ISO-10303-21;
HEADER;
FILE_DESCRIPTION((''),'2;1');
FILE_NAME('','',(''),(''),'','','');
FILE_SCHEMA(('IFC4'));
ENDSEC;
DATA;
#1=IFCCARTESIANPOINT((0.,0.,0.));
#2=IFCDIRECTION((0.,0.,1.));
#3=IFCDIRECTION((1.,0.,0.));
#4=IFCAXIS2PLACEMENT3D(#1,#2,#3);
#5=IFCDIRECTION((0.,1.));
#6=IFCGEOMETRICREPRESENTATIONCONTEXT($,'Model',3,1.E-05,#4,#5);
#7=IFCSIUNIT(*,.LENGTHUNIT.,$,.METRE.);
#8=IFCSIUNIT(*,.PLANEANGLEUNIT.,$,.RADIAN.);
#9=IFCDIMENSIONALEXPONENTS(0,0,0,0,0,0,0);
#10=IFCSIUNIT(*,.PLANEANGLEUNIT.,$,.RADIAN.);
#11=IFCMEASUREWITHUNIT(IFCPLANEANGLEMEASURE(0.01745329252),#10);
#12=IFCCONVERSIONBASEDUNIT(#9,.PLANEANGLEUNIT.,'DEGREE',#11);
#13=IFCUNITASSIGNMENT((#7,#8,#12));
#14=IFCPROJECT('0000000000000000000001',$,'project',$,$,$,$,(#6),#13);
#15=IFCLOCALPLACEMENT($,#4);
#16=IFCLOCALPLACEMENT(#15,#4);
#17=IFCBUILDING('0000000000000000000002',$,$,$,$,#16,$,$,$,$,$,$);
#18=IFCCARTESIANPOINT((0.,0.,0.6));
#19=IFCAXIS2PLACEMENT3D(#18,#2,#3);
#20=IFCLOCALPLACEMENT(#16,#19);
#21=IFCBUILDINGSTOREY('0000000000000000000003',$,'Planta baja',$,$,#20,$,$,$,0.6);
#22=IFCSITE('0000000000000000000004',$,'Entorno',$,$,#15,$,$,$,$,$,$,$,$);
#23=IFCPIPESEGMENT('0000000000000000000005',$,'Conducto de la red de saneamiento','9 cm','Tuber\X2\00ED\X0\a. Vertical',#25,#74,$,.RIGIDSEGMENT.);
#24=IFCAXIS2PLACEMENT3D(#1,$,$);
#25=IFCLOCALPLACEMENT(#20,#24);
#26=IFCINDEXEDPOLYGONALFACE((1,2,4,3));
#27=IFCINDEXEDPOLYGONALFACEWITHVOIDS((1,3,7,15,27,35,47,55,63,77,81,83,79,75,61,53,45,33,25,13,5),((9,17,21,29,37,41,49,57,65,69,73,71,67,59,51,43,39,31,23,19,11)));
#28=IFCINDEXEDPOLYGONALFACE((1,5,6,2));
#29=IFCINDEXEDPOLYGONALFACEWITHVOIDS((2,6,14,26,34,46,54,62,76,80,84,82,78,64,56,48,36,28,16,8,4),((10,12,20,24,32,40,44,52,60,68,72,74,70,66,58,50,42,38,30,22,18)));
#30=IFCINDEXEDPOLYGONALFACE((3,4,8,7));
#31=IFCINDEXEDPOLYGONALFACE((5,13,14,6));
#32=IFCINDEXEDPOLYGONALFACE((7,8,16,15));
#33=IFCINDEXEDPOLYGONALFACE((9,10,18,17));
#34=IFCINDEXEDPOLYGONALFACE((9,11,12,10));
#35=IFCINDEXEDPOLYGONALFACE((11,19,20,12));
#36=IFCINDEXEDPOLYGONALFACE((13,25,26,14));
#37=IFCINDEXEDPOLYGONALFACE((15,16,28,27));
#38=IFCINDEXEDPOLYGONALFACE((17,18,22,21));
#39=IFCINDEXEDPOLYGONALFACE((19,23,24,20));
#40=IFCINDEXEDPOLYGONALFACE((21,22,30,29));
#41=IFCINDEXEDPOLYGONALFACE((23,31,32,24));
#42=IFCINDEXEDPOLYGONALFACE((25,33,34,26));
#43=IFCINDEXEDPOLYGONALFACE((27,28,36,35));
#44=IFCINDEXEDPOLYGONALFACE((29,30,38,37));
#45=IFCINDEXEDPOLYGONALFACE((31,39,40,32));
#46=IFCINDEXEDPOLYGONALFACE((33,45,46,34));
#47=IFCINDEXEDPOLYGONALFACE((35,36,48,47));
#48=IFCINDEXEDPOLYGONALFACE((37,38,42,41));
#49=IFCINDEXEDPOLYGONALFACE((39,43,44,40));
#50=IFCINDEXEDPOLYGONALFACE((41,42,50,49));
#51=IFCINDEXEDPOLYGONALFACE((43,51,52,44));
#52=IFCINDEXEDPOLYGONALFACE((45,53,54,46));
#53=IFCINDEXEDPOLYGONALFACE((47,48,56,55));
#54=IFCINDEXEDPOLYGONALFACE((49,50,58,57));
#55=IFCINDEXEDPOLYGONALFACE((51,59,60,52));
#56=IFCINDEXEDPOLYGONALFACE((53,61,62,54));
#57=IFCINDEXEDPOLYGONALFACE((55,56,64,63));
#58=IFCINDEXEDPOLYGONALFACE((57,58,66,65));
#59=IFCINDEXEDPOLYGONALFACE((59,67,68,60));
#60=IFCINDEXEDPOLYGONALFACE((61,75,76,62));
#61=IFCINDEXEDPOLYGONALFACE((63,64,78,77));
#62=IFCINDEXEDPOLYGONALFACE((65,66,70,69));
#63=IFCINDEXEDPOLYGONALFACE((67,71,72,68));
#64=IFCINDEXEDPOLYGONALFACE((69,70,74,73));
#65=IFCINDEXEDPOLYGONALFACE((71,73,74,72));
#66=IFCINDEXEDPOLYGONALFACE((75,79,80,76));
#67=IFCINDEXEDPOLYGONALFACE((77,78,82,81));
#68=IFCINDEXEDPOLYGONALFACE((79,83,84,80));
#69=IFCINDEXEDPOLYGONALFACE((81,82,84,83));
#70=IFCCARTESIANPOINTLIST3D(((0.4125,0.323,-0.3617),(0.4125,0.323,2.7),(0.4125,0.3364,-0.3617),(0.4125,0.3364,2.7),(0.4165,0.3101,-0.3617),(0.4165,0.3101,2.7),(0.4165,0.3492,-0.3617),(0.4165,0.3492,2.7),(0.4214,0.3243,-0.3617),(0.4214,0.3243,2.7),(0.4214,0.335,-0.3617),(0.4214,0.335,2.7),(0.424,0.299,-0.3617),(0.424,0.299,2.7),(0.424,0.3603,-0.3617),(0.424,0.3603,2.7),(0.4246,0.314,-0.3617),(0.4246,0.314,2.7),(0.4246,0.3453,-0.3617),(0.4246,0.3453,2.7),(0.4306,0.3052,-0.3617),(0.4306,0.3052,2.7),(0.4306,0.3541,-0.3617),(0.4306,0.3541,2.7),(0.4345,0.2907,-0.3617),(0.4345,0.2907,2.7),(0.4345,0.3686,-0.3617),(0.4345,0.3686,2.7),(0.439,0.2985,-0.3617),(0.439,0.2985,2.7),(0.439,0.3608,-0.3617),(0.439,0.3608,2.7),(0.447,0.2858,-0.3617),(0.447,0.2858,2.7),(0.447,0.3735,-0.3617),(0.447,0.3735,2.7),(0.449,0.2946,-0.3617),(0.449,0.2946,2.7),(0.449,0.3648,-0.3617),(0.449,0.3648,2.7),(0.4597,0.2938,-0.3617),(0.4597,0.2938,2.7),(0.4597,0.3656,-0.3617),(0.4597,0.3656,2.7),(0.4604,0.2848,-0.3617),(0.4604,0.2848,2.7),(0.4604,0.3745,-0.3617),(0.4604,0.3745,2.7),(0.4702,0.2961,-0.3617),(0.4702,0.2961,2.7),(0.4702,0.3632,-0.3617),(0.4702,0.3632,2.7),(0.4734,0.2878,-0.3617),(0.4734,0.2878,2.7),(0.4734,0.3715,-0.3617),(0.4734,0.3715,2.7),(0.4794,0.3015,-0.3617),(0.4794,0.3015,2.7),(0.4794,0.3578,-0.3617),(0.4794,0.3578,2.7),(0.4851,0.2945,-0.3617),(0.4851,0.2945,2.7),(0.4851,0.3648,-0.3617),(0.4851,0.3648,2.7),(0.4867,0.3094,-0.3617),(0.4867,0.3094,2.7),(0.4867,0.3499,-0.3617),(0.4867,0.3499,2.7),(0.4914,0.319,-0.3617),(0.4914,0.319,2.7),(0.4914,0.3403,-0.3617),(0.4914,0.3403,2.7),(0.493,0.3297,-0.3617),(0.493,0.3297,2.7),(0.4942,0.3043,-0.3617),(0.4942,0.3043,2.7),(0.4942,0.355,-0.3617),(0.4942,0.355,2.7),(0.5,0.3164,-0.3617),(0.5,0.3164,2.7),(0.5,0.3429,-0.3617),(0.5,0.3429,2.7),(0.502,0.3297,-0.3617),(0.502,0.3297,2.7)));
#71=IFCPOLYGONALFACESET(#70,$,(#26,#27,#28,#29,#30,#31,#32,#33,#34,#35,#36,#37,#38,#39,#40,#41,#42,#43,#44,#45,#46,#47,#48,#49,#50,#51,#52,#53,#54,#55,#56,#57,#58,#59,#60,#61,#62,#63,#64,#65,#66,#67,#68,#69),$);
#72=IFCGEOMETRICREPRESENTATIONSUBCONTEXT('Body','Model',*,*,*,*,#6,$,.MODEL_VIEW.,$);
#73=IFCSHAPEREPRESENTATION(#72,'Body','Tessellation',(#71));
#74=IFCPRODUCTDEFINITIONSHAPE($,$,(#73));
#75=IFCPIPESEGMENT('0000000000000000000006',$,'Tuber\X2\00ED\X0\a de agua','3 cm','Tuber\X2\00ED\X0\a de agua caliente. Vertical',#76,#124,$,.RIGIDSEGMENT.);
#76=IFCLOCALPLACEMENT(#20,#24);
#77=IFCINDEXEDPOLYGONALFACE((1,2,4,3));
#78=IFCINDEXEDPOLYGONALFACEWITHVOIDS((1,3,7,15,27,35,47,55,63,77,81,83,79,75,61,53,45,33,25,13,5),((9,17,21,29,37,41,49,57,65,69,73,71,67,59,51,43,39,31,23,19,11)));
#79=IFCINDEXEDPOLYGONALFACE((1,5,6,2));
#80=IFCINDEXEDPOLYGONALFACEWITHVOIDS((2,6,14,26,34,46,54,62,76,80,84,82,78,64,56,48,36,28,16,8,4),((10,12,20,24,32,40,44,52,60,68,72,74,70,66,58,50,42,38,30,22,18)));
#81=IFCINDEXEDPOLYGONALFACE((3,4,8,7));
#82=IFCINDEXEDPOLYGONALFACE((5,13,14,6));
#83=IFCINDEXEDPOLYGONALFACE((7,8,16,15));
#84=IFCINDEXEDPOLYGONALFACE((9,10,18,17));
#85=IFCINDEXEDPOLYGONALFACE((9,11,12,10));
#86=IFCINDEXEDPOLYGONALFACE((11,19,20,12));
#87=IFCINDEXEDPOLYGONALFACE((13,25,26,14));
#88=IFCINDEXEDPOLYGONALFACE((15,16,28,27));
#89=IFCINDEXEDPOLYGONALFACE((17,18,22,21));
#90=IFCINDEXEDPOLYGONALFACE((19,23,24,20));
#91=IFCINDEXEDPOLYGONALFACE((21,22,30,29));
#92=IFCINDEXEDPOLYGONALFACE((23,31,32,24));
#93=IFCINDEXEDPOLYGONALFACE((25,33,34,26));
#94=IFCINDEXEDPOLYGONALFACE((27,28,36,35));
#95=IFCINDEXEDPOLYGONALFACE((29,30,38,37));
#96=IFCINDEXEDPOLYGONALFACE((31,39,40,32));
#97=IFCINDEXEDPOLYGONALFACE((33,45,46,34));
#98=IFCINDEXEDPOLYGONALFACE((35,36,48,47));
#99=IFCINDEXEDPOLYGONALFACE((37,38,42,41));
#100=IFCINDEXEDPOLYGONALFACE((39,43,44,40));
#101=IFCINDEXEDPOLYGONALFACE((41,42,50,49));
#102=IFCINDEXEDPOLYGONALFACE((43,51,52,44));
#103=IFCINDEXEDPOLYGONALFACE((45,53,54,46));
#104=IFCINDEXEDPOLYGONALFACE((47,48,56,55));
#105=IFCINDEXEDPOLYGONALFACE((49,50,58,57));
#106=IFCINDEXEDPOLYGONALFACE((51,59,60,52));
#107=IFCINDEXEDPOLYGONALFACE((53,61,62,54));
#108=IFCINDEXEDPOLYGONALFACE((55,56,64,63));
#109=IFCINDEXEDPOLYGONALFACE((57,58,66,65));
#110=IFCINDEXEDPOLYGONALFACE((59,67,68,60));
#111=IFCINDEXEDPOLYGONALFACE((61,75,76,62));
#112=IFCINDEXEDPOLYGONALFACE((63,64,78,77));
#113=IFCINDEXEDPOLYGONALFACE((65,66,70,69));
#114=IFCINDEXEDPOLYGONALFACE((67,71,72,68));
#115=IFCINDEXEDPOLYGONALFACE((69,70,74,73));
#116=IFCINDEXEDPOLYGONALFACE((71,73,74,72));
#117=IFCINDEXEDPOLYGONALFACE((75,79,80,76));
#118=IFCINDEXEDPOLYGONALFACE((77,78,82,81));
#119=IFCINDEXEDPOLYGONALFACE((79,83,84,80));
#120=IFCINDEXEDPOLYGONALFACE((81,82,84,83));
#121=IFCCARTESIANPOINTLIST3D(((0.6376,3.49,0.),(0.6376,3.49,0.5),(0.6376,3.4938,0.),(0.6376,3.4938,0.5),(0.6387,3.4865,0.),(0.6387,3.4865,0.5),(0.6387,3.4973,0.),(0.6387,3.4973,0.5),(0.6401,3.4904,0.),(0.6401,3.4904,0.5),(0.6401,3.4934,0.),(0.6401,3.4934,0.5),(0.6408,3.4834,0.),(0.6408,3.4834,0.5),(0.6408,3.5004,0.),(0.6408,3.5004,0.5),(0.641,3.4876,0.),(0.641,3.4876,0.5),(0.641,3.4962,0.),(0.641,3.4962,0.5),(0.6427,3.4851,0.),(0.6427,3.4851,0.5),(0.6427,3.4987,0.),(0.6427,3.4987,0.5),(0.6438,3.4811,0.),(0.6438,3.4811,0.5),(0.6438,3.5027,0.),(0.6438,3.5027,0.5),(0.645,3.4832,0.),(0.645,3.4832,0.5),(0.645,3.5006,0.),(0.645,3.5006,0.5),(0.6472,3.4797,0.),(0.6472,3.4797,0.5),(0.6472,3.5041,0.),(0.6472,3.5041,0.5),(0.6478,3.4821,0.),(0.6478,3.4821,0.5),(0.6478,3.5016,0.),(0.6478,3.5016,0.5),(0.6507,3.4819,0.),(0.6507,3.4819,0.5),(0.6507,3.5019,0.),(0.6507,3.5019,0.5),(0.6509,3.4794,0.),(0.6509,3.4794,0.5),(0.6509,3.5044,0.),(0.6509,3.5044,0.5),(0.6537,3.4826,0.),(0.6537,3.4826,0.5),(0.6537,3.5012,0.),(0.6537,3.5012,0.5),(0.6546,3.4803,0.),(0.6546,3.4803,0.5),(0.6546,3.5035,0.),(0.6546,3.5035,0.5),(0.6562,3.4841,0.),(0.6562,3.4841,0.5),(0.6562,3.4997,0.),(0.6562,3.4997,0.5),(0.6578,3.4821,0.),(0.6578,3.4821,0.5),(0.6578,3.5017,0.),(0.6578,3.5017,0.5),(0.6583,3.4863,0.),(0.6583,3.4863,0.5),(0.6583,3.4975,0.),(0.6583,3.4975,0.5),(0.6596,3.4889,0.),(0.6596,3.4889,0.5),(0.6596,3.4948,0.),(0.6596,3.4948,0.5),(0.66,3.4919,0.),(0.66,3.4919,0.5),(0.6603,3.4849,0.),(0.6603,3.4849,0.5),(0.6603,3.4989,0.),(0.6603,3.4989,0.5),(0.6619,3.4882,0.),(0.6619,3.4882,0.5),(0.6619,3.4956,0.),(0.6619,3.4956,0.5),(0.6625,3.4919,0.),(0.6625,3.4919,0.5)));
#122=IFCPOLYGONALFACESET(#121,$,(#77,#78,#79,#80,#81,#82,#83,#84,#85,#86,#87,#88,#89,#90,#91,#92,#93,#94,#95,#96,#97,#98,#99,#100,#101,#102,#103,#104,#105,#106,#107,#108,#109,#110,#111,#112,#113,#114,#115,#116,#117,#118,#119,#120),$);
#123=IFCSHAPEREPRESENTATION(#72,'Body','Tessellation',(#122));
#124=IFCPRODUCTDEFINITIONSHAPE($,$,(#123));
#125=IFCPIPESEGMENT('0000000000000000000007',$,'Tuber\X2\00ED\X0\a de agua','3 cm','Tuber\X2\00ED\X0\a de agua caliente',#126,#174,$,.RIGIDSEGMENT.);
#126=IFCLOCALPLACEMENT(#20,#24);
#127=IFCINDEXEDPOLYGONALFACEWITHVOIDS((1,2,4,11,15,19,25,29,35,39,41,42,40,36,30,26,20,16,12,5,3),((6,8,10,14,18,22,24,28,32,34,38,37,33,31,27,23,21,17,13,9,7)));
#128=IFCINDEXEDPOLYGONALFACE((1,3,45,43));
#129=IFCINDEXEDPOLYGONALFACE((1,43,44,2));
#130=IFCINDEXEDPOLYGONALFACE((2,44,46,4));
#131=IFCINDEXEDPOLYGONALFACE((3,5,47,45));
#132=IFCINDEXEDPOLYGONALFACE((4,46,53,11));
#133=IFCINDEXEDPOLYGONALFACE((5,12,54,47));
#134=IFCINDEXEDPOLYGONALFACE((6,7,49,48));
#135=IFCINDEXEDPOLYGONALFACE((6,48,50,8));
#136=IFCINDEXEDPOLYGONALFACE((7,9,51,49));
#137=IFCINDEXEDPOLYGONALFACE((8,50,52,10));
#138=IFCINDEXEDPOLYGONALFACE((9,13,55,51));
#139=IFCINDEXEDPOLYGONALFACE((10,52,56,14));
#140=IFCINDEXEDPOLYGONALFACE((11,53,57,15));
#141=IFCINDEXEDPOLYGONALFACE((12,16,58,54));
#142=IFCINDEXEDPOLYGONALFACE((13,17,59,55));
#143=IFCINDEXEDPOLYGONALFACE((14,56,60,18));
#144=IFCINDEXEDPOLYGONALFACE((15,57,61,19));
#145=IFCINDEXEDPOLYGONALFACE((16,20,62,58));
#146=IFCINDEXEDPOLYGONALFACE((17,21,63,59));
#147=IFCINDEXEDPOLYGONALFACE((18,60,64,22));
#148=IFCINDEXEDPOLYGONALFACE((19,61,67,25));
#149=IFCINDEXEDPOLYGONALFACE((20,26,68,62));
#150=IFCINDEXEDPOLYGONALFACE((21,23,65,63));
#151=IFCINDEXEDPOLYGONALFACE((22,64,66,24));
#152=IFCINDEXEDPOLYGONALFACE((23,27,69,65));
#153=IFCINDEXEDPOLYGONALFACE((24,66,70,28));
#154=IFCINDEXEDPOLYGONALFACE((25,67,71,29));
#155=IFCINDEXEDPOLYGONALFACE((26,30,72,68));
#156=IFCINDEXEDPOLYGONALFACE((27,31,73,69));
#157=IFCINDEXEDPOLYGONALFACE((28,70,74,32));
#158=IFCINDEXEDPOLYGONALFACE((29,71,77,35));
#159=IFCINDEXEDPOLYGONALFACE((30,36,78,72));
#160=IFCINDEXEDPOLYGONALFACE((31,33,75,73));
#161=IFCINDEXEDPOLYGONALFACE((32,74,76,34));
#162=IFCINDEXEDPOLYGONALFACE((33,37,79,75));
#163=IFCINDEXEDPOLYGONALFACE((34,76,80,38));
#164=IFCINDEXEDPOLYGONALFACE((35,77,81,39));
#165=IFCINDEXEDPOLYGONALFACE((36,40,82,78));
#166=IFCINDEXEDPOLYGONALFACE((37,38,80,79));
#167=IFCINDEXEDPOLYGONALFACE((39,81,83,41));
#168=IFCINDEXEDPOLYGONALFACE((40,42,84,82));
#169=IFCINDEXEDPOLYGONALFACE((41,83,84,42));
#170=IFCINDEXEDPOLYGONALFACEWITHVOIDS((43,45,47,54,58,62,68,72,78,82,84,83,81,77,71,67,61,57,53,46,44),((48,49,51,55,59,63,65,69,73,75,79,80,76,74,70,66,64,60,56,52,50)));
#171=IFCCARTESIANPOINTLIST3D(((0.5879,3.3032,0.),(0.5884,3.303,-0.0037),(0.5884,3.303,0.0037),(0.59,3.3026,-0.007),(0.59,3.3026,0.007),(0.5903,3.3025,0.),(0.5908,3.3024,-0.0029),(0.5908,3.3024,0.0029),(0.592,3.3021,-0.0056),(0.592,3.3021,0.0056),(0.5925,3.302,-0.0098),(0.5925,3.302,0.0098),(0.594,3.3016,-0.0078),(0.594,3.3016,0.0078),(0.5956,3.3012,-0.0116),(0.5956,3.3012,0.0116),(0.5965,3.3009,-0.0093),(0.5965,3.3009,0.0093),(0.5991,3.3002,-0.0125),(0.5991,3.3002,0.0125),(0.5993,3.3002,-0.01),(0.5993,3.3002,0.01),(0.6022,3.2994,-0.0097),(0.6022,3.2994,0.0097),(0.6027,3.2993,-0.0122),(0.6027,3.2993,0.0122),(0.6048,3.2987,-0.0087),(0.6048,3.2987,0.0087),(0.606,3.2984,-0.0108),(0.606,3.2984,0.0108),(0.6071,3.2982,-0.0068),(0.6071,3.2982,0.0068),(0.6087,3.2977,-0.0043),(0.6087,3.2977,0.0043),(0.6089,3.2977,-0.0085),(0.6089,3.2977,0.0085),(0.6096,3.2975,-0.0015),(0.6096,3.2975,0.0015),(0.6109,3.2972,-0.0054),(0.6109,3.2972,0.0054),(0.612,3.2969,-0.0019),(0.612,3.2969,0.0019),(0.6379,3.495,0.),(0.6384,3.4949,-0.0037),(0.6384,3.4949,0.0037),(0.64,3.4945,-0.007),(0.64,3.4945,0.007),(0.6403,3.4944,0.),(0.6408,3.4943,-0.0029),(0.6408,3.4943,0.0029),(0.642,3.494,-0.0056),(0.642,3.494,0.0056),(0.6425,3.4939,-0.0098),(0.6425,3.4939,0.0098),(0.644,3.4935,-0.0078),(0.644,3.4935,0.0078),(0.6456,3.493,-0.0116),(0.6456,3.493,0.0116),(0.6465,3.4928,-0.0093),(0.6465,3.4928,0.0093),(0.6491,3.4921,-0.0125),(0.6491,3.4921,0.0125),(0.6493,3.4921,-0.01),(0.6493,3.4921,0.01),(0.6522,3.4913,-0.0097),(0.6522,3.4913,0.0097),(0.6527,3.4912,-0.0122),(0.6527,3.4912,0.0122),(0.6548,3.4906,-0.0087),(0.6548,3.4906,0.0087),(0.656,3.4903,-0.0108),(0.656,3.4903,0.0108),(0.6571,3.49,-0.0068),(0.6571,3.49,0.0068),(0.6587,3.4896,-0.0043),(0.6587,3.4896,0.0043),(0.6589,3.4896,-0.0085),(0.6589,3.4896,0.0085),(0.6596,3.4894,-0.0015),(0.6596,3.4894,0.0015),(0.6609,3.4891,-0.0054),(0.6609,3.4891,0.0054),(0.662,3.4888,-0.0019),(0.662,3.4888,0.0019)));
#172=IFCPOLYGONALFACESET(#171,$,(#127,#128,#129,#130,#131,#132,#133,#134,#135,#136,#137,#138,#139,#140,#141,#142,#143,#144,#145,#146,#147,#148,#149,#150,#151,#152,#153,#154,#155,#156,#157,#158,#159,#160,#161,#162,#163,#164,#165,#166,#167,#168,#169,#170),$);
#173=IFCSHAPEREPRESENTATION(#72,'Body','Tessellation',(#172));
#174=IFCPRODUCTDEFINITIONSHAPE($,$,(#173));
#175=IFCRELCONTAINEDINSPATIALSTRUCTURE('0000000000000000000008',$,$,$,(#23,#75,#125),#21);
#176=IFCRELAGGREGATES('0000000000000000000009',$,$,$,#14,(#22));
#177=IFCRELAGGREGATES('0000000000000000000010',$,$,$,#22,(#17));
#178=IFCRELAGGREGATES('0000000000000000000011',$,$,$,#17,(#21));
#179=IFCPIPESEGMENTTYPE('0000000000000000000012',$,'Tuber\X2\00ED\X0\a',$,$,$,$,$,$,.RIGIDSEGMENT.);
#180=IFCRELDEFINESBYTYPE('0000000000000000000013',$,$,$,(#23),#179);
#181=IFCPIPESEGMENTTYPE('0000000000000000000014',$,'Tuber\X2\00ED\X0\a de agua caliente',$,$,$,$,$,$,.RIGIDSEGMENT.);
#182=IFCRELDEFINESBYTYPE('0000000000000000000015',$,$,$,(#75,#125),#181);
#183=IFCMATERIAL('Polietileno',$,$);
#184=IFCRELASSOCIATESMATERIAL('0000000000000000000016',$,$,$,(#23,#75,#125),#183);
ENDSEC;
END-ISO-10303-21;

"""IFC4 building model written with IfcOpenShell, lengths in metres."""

from ifc_helpers import new_model, entity, si_unit, converted_unit, direction, frame, origin_with_axes, origin_2d_with_axis, place, context, subcontext, project, spatial, hollow_circle, extrude, material, type_object, element, save


model = new_model("IFC4")

# Units and contexts
model_context = context("Model", 3, precision=1e-05, world=origin_with_axes(), true_north=direction((0.0, 1.0)))
body_context = subcontext(model_context, "Body", "Model", "MODEL_VIEW")
ifc_project = project(units=[si_unit("LENGTHUNIT", "METRE"), si_unit("PLANEANGLEUNIT", "RADIAN"), converted_unit("PLANEANGLEUNIT", "DEGREE", entity("IfcPlaneAngleMeasure", 0.01745329252), si_unit("PLANEANGLEUNIT", "RADIAN"), dimensions=[0, 0, 0, 0, 0, 0, 0])], contexts=[model_context])

# Site, building, storey
site_placement = place(None, origin_with_axes())
site = spatial("IfcSite", under=ifc_project, at=site_placement, Name="Entorno")
building_placement = place(site_placement, origin_with_axes())
building = spatial("IfcBuilding", under=site, at=building_placement)
storey_placement = place(building_placement, frame((0.0, 0.0, 0.6), z_axis=(0.0, 0.0, 1.0), x_axis=(1.0, 0.0, 0.0)))
storey = spatial("IfcBuildingStorey", under=building, at=storey_placement, Name="Planta baja", Elevation=0.6)

# Shared definitions
ifc_material_1 = material(Name="Polietileno")

# Pipe segment
pipe_segment_type_1 = type_object("IfcPipeSegmentType", Name="Tubería", PredefinedType="RIGIDSEGMENT")
pipe_segment_1_placement = place(storey_placement, frame((0.457, 0.3297, -0.3617), z_axis=(0.0, 0.0, 1.0), x_axis=(1.0, 0.0, 0.0)))
element("IfcPipeSegment", 1, at=pipe_segment_1_placement, inside=storey, type_object=pipe_segment_type_1, material=ifc_material_1, Name="Conducto de la red de saneamiento", Description="9 cm", ObjectType="Tubería. Vertical", PredefinedType="RIGIDSEGMENT", context=body_context, shape_type="SweptSolid", body=[
    extrude(hollow_circle(Radius=0.045, WallThickness=0.009, at=origin_2d_with_axis()), origin_with_axes(), (0.0, 0.0, 1.0), 3.0617),
])

# Pipe segments
pipe_segment_type_2 = type_object("IfcPipeSegmentType", Name="Tubería de agua caliente", PredefinedType="RIGIDSEGMENT")
pipe_segment_2_placement = place(storey_placement, frame((0.65, 3.4919, 0.0), z_axis=(0.0, 0.0, 1.0), x_axis=(1.0, 0.0, 0.0)))
element("IfcPipeSegment", 2, at=pipe_segment_2_placement, inside=storey, type_object=pipe_segment_type_2, material=ifc_material_1, Name="Tubería de agua", Description="3 cm", ObjectType="Tubería de agua caliente. Vertical", PredefinedType="RIGIDSEGMENT", context=body_context, shape_type="SweptSolid", body=[
    extrude(hollow_circle(Radius=0.0125, WallThickness=0.0025, at=origin_2d_with_axis()), origin_with_axes(), (0.0, 0.0, 1.0), 0.5),
])
pipe_segment_3_placement = place(storey_placement, frame((0.6, 3.3, 0.0), z_axis=(0.252144, 0.96769, 0.0), x_axis=(-0.96769, 0.252144, 0.0)))
element("IfcPipeSegment", 3, at=pipe_segment_3_placement, inside=storey, type_object=pipe_segment_type_2, material=ifc_material_1, Name="Tubería de agua", Description="3 cm", ObjectType="Tubería de agua caliente", PredefinedType="RIGIDSEGMENT", context=body_context, shape_type="SweptSolid", body=[
    extrude(hollow_circle(Radius=0.0125, WallThickness=0.0025, at=origin_2d_with_axis()), origin_with_axes(), (0.0, 0.0, 1.0), 0.1983),
])

save(model, "model.ifc")
